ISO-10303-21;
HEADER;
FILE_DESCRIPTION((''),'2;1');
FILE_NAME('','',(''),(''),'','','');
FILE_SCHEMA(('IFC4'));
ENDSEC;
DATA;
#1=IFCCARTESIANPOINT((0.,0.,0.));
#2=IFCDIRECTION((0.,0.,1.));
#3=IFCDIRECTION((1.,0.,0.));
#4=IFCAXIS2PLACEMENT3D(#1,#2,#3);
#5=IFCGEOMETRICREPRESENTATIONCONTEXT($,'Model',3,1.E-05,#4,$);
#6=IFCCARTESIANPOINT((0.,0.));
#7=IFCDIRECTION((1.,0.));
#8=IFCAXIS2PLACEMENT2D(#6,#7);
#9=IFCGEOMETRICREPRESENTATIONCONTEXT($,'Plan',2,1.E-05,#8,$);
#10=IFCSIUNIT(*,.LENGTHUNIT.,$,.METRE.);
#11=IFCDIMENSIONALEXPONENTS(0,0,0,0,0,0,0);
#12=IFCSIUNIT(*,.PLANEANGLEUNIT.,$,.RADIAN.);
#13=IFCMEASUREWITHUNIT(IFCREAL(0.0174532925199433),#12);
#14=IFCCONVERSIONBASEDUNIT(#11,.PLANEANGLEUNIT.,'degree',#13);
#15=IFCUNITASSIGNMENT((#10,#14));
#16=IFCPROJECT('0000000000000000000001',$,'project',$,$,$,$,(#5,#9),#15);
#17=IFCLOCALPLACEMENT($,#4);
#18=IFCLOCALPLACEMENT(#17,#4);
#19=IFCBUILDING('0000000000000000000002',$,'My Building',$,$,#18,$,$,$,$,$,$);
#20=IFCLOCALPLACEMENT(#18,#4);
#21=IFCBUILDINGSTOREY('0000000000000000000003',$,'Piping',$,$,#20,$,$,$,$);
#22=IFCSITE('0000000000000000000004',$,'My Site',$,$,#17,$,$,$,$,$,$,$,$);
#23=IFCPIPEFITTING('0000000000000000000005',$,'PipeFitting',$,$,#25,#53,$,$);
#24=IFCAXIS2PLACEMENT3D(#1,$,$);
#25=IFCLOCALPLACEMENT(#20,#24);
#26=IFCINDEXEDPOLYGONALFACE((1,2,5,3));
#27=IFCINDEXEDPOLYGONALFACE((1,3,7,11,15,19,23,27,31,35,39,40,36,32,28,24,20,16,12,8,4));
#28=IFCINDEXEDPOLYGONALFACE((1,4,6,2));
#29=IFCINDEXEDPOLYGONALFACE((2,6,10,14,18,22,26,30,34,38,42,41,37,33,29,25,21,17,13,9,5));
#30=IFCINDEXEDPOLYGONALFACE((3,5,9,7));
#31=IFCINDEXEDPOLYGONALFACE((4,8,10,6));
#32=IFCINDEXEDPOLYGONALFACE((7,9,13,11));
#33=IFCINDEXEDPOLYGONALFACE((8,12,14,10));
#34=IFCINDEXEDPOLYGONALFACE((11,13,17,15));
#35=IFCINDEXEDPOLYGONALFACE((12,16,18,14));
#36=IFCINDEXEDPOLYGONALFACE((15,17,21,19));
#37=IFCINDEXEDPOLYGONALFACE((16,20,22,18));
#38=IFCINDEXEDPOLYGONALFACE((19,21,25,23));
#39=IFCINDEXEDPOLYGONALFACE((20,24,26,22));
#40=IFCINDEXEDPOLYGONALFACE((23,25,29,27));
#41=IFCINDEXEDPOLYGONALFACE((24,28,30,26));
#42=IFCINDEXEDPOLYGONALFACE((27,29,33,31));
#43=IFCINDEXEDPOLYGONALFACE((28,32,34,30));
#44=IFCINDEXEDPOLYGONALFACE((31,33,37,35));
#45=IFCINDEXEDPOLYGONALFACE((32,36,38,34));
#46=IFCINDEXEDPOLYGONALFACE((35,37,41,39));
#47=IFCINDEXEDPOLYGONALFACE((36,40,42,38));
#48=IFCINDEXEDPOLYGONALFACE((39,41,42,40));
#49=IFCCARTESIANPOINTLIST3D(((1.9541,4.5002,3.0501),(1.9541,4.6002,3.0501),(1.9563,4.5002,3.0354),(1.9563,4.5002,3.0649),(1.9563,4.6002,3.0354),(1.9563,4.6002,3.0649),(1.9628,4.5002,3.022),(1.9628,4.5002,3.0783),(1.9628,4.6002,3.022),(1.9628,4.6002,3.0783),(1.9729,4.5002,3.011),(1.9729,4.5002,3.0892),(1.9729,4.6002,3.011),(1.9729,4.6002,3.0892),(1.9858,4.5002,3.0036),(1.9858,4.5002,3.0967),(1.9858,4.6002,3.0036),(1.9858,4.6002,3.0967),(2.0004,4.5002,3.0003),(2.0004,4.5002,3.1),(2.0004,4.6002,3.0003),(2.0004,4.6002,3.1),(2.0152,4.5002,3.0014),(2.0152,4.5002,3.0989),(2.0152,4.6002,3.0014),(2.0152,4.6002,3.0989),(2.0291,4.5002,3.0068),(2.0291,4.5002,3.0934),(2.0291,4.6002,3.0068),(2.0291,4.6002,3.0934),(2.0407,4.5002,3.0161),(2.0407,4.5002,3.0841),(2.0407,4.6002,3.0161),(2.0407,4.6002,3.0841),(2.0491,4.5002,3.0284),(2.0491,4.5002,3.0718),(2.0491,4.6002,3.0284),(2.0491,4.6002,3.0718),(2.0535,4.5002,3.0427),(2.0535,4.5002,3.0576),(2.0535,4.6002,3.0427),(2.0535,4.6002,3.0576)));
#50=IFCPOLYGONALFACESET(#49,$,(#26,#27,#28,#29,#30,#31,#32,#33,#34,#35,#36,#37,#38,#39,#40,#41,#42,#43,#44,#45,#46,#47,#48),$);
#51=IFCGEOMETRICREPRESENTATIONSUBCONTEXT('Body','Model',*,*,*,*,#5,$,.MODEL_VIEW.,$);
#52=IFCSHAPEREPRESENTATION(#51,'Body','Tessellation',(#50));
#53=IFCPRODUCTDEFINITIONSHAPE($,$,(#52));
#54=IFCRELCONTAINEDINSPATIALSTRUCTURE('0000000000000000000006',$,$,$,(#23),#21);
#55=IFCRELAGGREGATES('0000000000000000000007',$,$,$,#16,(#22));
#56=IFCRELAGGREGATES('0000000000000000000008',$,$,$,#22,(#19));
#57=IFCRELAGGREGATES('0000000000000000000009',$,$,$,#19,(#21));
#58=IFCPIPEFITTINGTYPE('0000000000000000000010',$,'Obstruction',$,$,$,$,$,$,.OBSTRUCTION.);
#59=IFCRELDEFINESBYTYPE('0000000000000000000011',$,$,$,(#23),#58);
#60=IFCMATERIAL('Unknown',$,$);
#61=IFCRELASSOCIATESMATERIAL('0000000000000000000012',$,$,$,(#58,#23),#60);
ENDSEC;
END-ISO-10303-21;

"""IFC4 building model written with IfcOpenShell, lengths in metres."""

from ifc_helpers import new_model, entity, si_unit, converted_unit, frame, origin_with_axes, origin_2d_with_axis, place, context, subcontext, project, spatial, circle, extrude, material, material_profile, profile_set, profile_usage, type_object, element, save


model = new_model("IFC4")

# Units and contexts
model_context = context("Model", 3, precision=1e-05, world=origin_with_axes())
plan_context = context("Plan", 2, precision=1e-05, world=origin_2d_with_axis())
body_context = subcontext(model_context, "Body", "Model", "MODEL_VIEW")
ifc_project = project(units=[si_unit("LENGTHUNIT", "METRE"), converted_unit("PLANEANGLEUNIT", "degree", entity("IfcReal", 0.0174532925199433), si_unit("PLANEANGLEUNIT", "RADIAN"), dimensions=[0, 0, 0, 0, 0, 0, 0])], contexts=[model_context, plan_context])

# Site, building, storey
site_placement = place(None, origin_with_axes())
site = spatial("IfcSite", under=ifc_project, at=site_placement, Name="My Site")
building_placement = place(site_placement, origin_with_axes())
building = spatial("IfcBuilding", under=site, at=building_placement, Name="My Building")
storey_placement = place(building_placement, origin_with_axes())
storey = spatial("IfcBuildingStorey", under=building, at=storey_placement, Name="Piping")

# Shared definitions
ifc_material = material(Name="Unknown")

# Pipe fitting
ifc_material_profile_1 = material_profile(ifc_material, circle(Radius=0.05))
ifc_profile_set_1 = profile_set([ifc_material_profile_1])
pipe_fitting_type_1 = type_object("IfcPipeFittingType", Name="Obstruction", PredefinedType="OBSTRUCTION", material=ifc_profile_set_1)
ifc_profile_usage_1 = profile_usage(ifc_profile_set_1, cardinal=5)
pipe_fitting_1_placement = place(storey_placement, frame((2.0041, 4.6002, 3.0501), z_axis=(0.0, -1.0, -0.000001), x_axis=(-1.0, 0.0, 0.000001)))
element("IfcPipeFitting", 1, at=pipe_fitting_1_placement, inside=storey, type_object=pipe_fitting_type_1, material=ifc_profile_usage_1, Name="PipeFitting", context=body_context, shape_type="SweptSolid", body=[
    extrude(circle(Radius=0.05), origin_with_axes(), (0.0, 0.0, 1.0), 0.1),
])

save(model, "model.ifc")
